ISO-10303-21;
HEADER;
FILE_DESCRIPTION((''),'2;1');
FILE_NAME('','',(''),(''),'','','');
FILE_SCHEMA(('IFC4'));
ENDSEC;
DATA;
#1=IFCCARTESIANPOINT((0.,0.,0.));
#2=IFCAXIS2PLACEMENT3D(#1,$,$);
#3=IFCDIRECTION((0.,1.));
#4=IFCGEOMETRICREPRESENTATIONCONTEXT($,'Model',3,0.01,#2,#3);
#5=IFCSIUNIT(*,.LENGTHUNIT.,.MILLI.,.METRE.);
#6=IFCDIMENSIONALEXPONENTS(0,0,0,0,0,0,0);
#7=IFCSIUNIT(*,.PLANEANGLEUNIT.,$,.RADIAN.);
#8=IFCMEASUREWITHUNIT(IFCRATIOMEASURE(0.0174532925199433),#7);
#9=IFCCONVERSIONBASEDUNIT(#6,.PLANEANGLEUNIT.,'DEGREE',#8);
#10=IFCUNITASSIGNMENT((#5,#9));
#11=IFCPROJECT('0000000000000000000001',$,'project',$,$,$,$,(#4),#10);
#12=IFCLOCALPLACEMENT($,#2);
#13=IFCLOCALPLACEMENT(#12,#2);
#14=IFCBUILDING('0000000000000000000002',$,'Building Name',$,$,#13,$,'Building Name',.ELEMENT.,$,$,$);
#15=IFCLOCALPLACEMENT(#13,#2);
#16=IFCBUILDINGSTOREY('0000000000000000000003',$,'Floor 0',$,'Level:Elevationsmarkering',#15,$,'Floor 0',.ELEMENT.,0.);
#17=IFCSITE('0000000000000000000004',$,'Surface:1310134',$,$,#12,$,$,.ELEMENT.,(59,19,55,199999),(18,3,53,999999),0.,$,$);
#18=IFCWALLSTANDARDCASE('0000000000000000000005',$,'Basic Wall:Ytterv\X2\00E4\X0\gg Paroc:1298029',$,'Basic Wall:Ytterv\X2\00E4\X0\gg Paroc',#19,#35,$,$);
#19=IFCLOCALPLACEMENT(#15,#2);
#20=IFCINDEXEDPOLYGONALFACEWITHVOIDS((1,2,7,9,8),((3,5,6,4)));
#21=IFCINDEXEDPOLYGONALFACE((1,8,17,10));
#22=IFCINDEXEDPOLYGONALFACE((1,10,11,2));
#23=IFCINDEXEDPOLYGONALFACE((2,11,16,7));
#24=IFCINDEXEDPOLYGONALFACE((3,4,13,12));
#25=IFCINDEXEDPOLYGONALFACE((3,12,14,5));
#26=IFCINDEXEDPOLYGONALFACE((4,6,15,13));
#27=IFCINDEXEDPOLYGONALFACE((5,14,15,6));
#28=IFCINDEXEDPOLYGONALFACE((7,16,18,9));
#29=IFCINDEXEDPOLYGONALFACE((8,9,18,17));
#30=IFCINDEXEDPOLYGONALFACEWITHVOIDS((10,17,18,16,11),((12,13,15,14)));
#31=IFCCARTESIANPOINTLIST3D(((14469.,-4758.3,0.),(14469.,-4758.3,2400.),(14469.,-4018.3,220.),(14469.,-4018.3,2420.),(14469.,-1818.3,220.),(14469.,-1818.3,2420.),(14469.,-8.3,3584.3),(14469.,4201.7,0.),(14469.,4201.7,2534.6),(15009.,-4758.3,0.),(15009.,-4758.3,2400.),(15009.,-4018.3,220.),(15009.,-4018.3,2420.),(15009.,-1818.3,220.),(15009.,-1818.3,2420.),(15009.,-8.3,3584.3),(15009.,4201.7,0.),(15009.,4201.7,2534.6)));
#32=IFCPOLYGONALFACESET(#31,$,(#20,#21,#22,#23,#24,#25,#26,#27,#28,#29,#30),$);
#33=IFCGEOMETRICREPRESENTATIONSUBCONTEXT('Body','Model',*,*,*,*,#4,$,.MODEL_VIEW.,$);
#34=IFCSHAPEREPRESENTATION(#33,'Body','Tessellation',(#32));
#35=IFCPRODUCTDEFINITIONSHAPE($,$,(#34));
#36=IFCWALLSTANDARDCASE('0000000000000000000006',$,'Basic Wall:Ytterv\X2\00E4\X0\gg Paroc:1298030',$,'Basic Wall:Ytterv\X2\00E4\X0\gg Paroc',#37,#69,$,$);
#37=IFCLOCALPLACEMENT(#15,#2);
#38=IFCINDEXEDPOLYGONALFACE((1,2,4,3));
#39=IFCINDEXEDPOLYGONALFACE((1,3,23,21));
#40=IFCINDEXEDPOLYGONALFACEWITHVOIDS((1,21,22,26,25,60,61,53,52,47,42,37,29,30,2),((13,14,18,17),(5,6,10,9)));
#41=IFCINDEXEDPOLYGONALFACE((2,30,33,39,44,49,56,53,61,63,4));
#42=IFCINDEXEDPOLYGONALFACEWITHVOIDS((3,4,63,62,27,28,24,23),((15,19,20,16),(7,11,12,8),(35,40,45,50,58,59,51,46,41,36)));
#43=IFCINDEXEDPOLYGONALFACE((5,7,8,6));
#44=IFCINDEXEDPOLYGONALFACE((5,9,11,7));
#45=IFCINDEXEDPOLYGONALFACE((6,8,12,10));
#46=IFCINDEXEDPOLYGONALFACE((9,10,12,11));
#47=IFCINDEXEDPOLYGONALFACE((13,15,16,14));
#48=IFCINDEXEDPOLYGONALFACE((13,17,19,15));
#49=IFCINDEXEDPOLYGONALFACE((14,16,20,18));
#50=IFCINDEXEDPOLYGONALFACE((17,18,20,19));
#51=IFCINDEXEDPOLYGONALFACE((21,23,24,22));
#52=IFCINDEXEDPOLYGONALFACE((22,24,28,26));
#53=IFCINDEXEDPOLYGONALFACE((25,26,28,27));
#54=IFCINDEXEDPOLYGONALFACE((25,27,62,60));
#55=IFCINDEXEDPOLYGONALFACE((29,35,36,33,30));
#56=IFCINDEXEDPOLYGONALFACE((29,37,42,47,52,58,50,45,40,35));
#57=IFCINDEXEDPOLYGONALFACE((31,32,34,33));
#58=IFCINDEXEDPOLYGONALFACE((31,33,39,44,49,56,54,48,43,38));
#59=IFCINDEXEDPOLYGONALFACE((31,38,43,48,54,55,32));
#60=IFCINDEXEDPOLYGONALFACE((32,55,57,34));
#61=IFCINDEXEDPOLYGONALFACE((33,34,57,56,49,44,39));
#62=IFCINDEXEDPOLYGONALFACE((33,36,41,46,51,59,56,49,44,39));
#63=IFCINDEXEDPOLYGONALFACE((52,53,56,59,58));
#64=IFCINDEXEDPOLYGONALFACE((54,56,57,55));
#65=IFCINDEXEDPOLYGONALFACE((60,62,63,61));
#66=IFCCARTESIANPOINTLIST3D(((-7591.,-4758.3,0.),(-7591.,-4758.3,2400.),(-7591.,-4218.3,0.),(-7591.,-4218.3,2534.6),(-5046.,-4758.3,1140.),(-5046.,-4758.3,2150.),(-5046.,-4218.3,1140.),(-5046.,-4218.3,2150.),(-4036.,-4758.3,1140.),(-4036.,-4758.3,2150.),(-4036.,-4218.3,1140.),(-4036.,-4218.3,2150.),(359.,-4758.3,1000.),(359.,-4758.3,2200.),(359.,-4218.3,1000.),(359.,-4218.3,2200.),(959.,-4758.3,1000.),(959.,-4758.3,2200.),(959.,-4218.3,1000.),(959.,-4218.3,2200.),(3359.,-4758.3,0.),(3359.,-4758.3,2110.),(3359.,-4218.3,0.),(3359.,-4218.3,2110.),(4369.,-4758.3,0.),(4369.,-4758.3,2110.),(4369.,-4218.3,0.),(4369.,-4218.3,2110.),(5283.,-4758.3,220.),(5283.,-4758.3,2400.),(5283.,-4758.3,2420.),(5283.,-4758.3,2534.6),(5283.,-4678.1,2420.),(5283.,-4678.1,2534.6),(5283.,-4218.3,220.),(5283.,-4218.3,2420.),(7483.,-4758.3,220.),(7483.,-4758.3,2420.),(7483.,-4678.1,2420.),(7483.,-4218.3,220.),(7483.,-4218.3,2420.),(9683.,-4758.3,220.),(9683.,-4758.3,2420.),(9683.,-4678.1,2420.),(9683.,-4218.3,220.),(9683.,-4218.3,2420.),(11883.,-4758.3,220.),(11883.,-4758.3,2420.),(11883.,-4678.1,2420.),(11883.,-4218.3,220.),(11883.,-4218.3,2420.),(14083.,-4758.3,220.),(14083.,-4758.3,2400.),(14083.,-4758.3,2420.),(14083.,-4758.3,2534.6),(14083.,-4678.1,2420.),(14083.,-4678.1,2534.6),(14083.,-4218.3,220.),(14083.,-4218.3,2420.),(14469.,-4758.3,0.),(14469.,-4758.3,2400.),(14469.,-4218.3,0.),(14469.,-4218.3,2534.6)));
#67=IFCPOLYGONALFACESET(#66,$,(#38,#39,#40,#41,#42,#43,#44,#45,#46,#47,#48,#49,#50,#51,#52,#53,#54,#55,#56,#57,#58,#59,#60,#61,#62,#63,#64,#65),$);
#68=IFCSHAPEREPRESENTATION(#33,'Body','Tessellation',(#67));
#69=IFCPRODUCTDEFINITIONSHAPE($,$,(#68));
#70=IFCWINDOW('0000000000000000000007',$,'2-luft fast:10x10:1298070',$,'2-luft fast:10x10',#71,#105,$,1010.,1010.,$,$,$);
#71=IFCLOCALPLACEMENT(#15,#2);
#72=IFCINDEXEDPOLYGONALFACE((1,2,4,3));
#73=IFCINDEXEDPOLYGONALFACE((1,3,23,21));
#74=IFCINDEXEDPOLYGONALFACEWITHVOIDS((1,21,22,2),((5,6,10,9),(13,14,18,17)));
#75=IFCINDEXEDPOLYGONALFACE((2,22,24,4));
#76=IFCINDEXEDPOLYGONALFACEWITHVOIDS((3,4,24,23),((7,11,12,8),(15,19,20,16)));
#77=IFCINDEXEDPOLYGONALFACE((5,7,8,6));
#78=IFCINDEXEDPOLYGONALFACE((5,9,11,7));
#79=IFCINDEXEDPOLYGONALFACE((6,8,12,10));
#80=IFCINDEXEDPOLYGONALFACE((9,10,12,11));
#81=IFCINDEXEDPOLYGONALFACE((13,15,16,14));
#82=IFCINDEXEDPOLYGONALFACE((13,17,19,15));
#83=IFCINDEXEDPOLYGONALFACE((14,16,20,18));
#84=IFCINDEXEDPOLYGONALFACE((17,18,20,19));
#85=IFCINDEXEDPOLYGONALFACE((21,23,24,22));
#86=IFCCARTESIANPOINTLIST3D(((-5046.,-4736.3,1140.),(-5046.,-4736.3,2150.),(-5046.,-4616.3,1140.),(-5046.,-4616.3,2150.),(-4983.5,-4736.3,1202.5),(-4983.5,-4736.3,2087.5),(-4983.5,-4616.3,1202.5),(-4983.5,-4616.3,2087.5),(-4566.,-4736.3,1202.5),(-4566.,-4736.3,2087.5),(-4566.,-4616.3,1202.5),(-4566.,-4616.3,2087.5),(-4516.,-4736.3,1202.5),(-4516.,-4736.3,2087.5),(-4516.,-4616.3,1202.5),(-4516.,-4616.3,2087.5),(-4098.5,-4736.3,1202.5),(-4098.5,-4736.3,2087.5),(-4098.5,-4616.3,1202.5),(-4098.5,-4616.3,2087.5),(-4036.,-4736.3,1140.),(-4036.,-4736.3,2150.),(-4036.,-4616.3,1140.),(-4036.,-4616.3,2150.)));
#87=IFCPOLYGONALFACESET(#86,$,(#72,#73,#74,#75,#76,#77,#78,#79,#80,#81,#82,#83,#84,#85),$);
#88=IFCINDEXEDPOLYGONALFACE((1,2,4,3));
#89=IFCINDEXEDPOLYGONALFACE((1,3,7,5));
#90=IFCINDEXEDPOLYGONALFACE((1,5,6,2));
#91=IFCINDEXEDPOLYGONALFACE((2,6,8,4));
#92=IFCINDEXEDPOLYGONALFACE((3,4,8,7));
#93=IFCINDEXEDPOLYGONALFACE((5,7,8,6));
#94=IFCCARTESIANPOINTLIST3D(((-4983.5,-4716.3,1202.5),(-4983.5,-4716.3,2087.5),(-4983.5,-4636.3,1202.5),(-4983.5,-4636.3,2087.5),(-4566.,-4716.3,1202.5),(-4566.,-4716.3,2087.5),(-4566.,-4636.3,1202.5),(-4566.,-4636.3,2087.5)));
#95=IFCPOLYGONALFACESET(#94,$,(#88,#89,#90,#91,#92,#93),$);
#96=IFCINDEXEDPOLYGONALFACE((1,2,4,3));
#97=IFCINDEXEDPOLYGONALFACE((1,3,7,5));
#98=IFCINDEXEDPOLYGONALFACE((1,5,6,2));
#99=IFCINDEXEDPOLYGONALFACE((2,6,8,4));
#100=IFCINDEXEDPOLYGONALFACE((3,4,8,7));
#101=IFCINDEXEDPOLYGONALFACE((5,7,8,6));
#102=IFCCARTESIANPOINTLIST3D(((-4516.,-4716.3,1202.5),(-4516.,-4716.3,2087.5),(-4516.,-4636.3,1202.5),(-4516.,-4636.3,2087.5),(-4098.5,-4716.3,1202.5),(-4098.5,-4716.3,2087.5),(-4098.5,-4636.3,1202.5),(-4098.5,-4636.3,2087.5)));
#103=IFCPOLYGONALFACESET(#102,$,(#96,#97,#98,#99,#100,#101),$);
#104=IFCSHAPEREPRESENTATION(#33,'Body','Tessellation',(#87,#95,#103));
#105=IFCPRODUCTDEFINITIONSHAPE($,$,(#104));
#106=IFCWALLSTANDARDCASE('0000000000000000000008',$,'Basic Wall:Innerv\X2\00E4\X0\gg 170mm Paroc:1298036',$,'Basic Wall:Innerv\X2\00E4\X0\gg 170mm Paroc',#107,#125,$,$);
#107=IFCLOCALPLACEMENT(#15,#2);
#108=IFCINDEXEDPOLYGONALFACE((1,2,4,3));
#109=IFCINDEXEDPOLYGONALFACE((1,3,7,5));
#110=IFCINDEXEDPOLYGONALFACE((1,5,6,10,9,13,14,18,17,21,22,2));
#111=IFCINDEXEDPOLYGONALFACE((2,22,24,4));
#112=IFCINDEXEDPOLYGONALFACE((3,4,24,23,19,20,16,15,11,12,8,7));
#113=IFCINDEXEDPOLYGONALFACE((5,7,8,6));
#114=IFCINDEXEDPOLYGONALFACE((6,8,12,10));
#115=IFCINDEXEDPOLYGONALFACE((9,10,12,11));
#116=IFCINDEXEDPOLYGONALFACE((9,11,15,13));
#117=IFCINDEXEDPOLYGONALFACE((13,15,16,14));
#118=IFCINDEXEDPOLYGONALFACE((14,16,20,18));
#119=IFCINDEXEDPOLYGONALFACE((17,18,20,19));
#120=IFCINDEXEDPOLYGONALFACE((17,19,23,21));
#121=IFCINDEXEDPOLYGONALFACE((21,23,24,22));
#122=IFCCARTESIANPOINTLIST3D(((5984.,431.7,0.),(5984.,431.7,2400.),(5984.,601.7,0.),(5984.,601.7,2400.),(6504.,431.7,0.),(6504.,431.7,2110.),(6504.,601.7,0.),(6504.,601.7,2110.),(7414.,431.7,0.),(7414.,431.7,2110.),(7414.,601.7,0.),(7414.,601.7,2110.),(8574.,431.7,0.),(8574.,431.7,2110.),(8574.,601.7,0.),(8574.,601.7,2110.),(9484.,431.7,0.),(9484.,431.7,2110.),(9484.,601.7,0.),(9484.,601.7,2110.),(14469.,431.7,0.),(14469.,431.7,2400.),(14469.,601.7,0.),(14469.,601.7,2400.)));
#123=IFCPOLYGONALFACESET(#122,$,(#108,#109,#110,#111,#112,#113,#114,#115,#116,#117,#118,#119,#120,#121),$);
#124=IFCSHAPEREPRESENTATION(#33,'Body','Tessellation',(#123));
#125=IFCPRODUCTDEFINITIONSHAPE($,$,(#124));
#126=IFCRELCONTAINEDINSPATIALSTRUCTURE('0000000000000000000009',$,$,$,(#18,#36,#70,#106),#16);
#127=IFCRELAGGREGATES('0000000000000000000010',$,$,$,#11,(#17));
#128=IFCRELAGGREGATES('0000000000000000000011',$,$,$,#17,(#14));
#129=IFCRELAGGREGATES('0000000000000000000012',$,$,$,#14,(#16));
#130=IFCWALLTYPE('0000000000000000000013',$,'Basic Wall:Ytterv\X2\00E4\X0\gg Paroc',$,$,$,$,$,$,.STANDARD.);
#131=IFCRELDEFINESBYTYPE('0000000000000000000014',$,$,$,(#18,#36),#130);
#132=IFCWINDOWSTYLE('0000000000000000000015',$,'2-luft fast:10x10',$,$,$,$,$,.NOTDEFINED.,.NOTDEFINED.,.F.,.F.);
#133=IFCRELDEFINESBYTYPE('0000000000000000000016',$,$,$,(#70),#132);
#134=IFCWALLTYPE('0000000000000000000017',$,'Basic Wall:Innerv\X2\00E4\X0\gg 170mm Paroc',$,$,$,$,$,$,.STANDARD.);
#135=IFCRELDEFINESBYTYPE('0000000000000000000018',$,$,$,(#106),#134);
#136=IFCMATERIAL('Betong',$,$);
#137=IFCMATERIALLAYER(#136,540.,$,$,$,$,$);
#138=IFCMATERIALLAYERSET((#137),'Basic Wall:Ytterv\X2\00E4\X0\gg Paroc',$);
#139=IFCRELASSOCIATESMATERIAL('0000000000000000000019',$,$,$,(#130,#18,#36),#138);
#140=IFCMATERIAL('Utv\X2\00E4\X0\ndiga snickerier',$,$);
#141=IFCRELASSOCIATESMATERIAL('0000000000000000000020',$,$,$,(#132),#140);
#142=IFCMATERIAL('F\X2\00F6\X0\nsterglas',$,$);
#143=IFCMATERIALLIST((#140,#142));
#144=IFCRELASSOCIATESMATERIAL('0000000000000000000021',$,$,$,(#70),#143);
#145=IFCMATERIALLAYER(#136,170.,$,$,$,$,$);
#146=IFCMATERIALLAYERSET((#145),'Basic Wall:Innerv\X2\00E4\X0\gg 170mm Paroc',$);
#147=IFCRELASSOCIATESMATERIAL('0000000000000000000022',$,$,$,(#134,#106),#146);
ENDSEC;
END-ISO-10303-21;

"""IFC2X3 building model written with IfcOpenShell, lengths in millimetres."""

from ifc_helpers import new_model, entity, si_unit, converted_unit, direction, frame, frame_2d, origin, place, context, subcontext, project, spatial, polyline, rectangle, outline, extrude, clip, bounded_halfspace, source, transform, mapped, material, material_list, layer, layer_set, layer_usage, type_object, type_shapes, element, fill, save


model = new_model("IFC2X3")

# Units and contexts
model_context = context("Model", 3, precision=0.01, world=origin(), true_north=direction((0.0, 1.0)))
body_context = subcontext(model_context, "Body", "Model", "MODEL_VIEW")
ifc_project = project(units=[si_unit("LENGTHUNIT", "METRE", prefix="MILLI"), converted_unit("PLANEANGLEUNIT", "DEGREE", entity("IfcRatioMeasure", 0.0174532925199433), si_unit("PLANEANGLEUNIT", "RADIAN"), dimensions=[0, 0, 0, 0, 0, 0, 0])], contexts=[model_context])

# Site, building, storey
site_placement = place(None, origin())
site = spatial("IfcSite", under=ifc_project, at=site_placement, Name="Surface:1310134", CompositionType="ELEMENT", RefLatitude=(59, 19, 55, 199999), RefLongitude=(18, 3, 53, 999999), RefElevation=0.0)
building_placement = place(site_placement, origin())
building = spatial("IfcBuilding", under=site, at=building_placement, Name="Building Name", LongName="Building Name", CompositionType="ELEMENT")
storey_placement = place(building_placement, origin())
storey = spatial("IfcBuildingStorey", under=building, at=storey_placement, Name="Floor 0", ObjectType="Level:Elevationsmarkering", LongName="Floor 0", CompositionType="ELEMENT", Elevation=0.0)

# Wall, opening
ifc_material_1 = material(Name="Betong")
ifc_layer_1 = layer(ifc_material_1, 540.0)
ifc_layer_set_1 = layer_set([ifc_layer_1], Name="Basic Wall:Yttervägg Paroc")
ifc_layer_usage_1 = layer_usage(ifc_layer_set_1, "AXIS2", "NEGATIVE", 270.0)
wall_type_1 = type_object("IfcWallType", Name="Basic Wall:Yttervägg Paroc", PredefinedType="STANDARD", material=ifc_layer_set_1)
wall_1_placement = place(storey_placement, frame((14739.0, 4201.7, 0.0), z_axis=(0.0, 0.0, 1.0), x_axis=(0.0, -1.0, 0.0)))
wall_1 = element("IfcWallStandardCase", 1, at=wall_1_placement, inside=storey, type_object=wall_type_1, material=ifc_layer_usage_1, Name="Basic Wall:Yttervägg Paroc:1298029", ObjectType="Basic Wall:Yttervägg Paroc", context=body_context, shape_type="Clipping", body=[
    clip(clip(extrude(rectangle(XDim=8960.0, YDim=540.0, at=frame_2d((4480.0, 0.0), x_axis=(-1.0, 0.0))), origin(), (0.0, 0.0, 1.0), 3584.3), bounded_halfspace(frame((0.0, 270.0, 2534.6), z_axis=(-0.241922, 0.0, 0.970296), x_axis=(0.0, -1.0, 0.0)), False, frame((0.0, 270.0, 2534.6)), polyline([(0.0, 0.0), (0.0, -540.0), (4210.0, -540.0), (4210.0, 0.0), (0.0, 0.0)]))), bounded_halfspace(frame((8960.0, -270.0, 2400.0), z_axis=(0.241922, 0.0, 0.970296), x_axis=(0.0, 1.0, 0.0)), False, frame((8960.0, -270.0, 2400.0)), polyline([(0.0, 0.0), (0.0, 540.0), (-4750.0, 540.0), (-4750.0, 0.0), (-540.0, 0.0), (0.0, 0.0)]))),
])
opening_1_placement = place(wall_1_placement, frame((8220.0, 270.0, 220.0)))
element("IfcOpeningElement", 2, at=opening_1_placement, cuts=wall_1, ObjectType="Opening", context=body_context, shape_type="SweptSolid", body=[
    extrude(rectangle(XDim=2200.0, YDim=2200.0, at=frame_2d((1100.0, 1100.0), x_axis=(1.0, 0.0))), frame((0.0, 0.0, 0.0), z_axis=(0.0, -1.0, 0.0), x_axis=(0.0, 0.0, 1.0)), (0.0, 0.0, 1.0), 540.0),
])

# Wall, openings, window
ifc_layer_usage_2 = layer_usage(ifc_layer_set_1, "AXIS2", "NEGATIVE", 270.0)
wall_2_placement = place(storey_placement, frame((14469.0, -4488.3, 0.0), z_axis=(0.0, 0.0, 1.0), x_axis=(-1.0, 0.0, 0.0)))
wall_2 = element("IfcWallStandardCase", 3, at=wall_2_placement, inside=storey, type_object=wall_type_1, material=ifc_layer_usage_2, Name="Basic Wall:Yttervägg Paroc:1298030", ObjectType="Basic Wall:Yttervägg Paroc", context=body_context, shape_type="Clipping", body=[
    clip(extrude(rectangle(XDim=22060.0, YDim=540.0, at=frame_2d((11030.0, 0.0), x_axis=(-1.0, 0.0))), origin(), (0.0, 0.0, 1.0), 2534.6), bounded_halfspace(frame((0.0, -270.0, 2534.6), z_axis=(0.0, 0.241922, 0.970296), x_axis=(-1.0, 0.0, 0.0)), False, frame((0.0, -270.0, 2534.6)), polyline([(0.0, 0.0), (21520.0, 0.0), (22060.0, 0.0), (22060.0, 540.0), (9186.0, 540.0), (9186.0, 459.8), (386.0, 459.8), (386.0, 540.0), (0.0, 540.0), (0.0, 0.0)]))),
])
opening_2_placement = place(wall_2_placement, frame((10100.0, -270.0, 0.0)))
element("IfcOpeningElement", 4, at=opening_2_placement, cuts=wall_2, ObjectType="Opening", context=body_context, shape_type="SweptSolid", body=[
    extrude(rectangle(XDim=2110.0, YDim=1010.0, at=frame_2d((1055.0, 505.0), x_axis=(1.0, 0.0))), frame((0.0, 0.0, 0.0), z_axis=(0.0, 1.0, 0.0), x_axis=(0.0, 0.0, 1.0)), (0.0, 0.0, 1.0), 540.0),
])
opening_3_placement = place(wall_2_placement, frame((9186.0, 270.0, 220.0)))
element("IfcOpeningElement", 5, at=opening_3_placement, cuts=wall_2, ObjectType="Opening", context=body_context, shape_type="SweptSolid", body=[
    extrude(rectangle(XDim=2200.0, YDim=2200.0, at=frame_2d((1100.0, 1100.0), x_axis=(1.0, 0.0))), frame((0.0, 0.0, 0.0), z_axis=(0.0, -1.0, 0.0), x_axis=(0.0, 0.0, 1.0)), (0.0, 0.0, 1.0), 540.0),
])
opening_4_placement = place(wall_2_placement, frame((2586.0, 270.0, 220.0)))
element("IfcOpeningElement", 6, at=opening_4_placement, cuts=wall_2, ObjectType="Opening", context=body_context, shape_type="SweptSolid", body=[
    extrude(rectangle(XDim=2200.0, YDim=2200.0, at=frame_2d((1100.0, 1100.0), x_axis=(1.0, 0.0))), frame((0.0, 0.0, 0.0), z_axis=(0.0, -1.0, 0.0), x_axis=(0.0, 0.0, 1.0)), (0.0, 0.0, 1.0), 540.0),
])
opening_5_placement = place(wall_2_placement, frame((4786.0, 270.0, 220.0)))
element("IfcOpeningElement", 7, at=opening_5_placement, cuts=wall_2, ObjectType="Opening", context=body_context, shape_type="SweptSolid", body=[
    extrude(rectangle(XDim=2200.0, YDim=2200.0, at=frame_2d((1100.0, 1100.0), x_axis=(1.0, 0.0))), frame((0.0, 0.0, 0.0), z_axis=(0.0, -1.0, 0.0), x_axis=(0.0, 0.0, 1.0)), (0.0, 0.0, 1.0), 540.0),
])
opening_6_placement = place(wall_2_placement, frame((6986.0, 270.0, 220.0)))
element("IfcOpeningElement", 8, at=opening_6_placement, cuts=wall_2, ObjectType="Opening", context=body_context, shape_type="SweptSolid", body=[
    extrude(rectangle(XDim=2200.0, YDim=2200.0, at=frame_2d((1100.0, 1100.0), x_axis=(1.0, 0.0))), frame((0.0, 0.0, 0.0), z_axis=(0.0, -1.0, 0.0), x_axis=(0.0, 0.0, 1.0)), (0.0, 0.0, 1.0), 540.0),
])
opening_7_placement = place(wall_2_placement, frame((14110.0, 270.0, 1000.0)))
element("IfcOpeningElement", 9, at=opening_7_placement, cuts=wall_2, ObjectType="Opening", context=body_context, shape_type="SweptSolid", body=[
    extrude(rectangle(XDim=1200.0, YDim=600.0, at=frame_2d((600.0, 300.0), x_axis=(1.0, 0.0))), frame((0.0, 0.0, 0.0), z_axis=(0.0, -1.0, 0.0), x_axis=(0.0, 0.0, 1.0)), (0.0, 0.0, 1.0), 540.0),
])
opening_8_placement = place(wall_2_placement, frame((18505.0, -270.0, 1140.0)))
opening_8 = element("IfcOpeningElement", 10, at=opening_8_placement, cuts=wall_2, ObjectType="Opening", context=body_context, shape_type="SweptSolid", body=[
    extrude(rectangle(XDim=1010.0, YDim=1010.0, at=frame_2d((505.0, 505.0), x_axis=(1.0, 0.0))), frame((0.0, 0.0, 0.0), z_axis=(0.0, 1.0, 0.0), x_axis=(0.0, 0.0, 1.0)), (0.0, 0.0, 1.0), 540.0),
])
ifc_material_2 = material(Name="Utvändiga snickerier")
ifc_material_3 = material(Name="Fönsterglas")
ifc_material_list_1 = material_list([ifc_material_2, ifc_material_3])
window_style = type_object("IfcWindowStyle", Name="2-luft fast:10x10", ConstructionType="NOTDEFINED", OperationType="NOTDEFINED", ParameterTakesPrecedence=False, Sizeable=False, material=ifc_material_2)
shared_shape_1 = source(origin(), body_context, "Body", "SweptSolid", [
    extrude(outline(polyline([(-505.0, -505.0), (505.0, -505.0), (505.0, 505.0), (-505.0, 505.0), (-505.0, -505.0)]), holes=[polyline([(25.0, -442.5), (25.0, 442.5), (442.5, 442.5), (442.5, -442.5), (25.0, -442.5)]), polyline([(-25.0, 442.5), (-25.0, -442.5), (-442.5, -442.5), (-442.5, 442.5), (-25.0, 442.5)])]), frame((505.0, 398.0, 505.0), z_axis=(0.0, 1.0, 0.0), x_axis=(1.0, 0.0, 0.0)), (0.0, 0.0, 1.0), 120.0),
    extrude(rectangle(XDim=80.0, YDim=417.5, at=frame_2d((0.0, 0.0), x_axis=(1.0, 0.0))), frame((738.7, 458.0, 62.5), z_axis=(0.0, 0.0, 1.0), x_axis=(0.0, 1.0, 0.0)), (0.0, 0.0, 1.0), 885.0),
    extrude(rectangle(XDim=80.0, YDim=417.5, at=frame_2d((0.0, 0.0), x_axis=(1.0, 0.0))), frame((271.2, 458.0, 62.5), z_axis=(0.0, 0.0, 1.0), x_axis=(0.0, 1.0, 0.0)), (0.0, 0.0, 1.0), 885.0),
])
type_shapes(window_style, [shared_shape_1])
window_placement = place(opening_8_placement, origin())
window = element("IfcWindow", 11, at=window_placement, inside=storey, type_object=window_style, material=ifc_material_list_1, Name="2-luft fast:10x10:1298070", ObjectType="2-luft fast:10x10", OverallHeight=1010.0, OverallWidth=1010.0, context=body_context, shape_type="MappedRepresentation", body=[
    mapped(shared_shape_1, transform((0.0, 0.0, 0.0), scale=1.0)),
])
fill(opening_8, window)

# Wall, openings
ifc_layer_2 = layer(ifc_material_1, 170.0)
ifc_layer_set_2 = layer_set([ifc_layer_2], Name="Basic Wall:Innervägg 170mm Paroc")
ifc_layer_usage_3 = layer_usage(ifc_layer_set_2, "AXIS2", "NEGATIVE", 85.0)
wall_type_2 = type_object("IfcWallType", Name="Basic Wall:Innervägg 170mm Paroc", PredefinedType="STANDARD", material=ifc_layer_set_2)
wall_3_placement = place(storey_placement, frame((5984.0, 516.7, 0.0)))
wall_3 = element("IfcWallStandardCase", 12, at=wall_3_placement, inside=storey, type_object=wall_type_2, material=ifc_layer_usage_3, Name="Basic Wall:Innervägg 170mm Paroc:1298036", ObjectType="Basic Wall:Innervägg 170mm Paroc", context=body_context, shape_type="SweptSolid", body=[
    extrude(rectangle(XDim=8485.0, YDim=170.0, at=frame_2d((4242.5, 0.0), x_axis=(-1.0, 0.0))), origin(), (0.0, 0.0, 1.0), 2400.0),
])
opening_9_placement = place(wall_3_placement, frame((2590.0, -85.0, 0.0)))
element("IfcOpeningElement", 13, at=opening_9_placement, cuts=wall_3, ObjectType="Opening", context=body_context, shape_type="SweptSolid", body=[
    extrude(rectangle(XDim=2110.0, YDim=910.0, at=frame_2d((1055.0, 455.0), x_axis=(1.0, 0.0))), frame((0.0, 0.0, 0.0), z_axis=(0.0, 1.0, 0.0), x_axis=(0.0, 0.0, 1.0)), (0.0, 0.0, 1.0), 170.0),
])
opening_10_placement = place(wall_3_placement, frame((520.0, -85.0, 0.0)))
element("IfcOpeningElement", 14, at=opening_10_placement, cuts=wall_3, ObjectType="Opening", context=body_context, shape_type="SweptSolid", body=[
    extrude(rectangle(XDim=2110.0, YDim=910.0, at=frame_2d((1055.0, 455.0), x_axis=(1.0, 0.0))), frame((0.0, 0.0, 0.0), z_axis=(0.0, 1.0, 0.0), x_axis=(0.0, 0.0, 1.0)), (0.0, 0.0, 1.0), 170.0),
])

save(model, "model.ifc")
